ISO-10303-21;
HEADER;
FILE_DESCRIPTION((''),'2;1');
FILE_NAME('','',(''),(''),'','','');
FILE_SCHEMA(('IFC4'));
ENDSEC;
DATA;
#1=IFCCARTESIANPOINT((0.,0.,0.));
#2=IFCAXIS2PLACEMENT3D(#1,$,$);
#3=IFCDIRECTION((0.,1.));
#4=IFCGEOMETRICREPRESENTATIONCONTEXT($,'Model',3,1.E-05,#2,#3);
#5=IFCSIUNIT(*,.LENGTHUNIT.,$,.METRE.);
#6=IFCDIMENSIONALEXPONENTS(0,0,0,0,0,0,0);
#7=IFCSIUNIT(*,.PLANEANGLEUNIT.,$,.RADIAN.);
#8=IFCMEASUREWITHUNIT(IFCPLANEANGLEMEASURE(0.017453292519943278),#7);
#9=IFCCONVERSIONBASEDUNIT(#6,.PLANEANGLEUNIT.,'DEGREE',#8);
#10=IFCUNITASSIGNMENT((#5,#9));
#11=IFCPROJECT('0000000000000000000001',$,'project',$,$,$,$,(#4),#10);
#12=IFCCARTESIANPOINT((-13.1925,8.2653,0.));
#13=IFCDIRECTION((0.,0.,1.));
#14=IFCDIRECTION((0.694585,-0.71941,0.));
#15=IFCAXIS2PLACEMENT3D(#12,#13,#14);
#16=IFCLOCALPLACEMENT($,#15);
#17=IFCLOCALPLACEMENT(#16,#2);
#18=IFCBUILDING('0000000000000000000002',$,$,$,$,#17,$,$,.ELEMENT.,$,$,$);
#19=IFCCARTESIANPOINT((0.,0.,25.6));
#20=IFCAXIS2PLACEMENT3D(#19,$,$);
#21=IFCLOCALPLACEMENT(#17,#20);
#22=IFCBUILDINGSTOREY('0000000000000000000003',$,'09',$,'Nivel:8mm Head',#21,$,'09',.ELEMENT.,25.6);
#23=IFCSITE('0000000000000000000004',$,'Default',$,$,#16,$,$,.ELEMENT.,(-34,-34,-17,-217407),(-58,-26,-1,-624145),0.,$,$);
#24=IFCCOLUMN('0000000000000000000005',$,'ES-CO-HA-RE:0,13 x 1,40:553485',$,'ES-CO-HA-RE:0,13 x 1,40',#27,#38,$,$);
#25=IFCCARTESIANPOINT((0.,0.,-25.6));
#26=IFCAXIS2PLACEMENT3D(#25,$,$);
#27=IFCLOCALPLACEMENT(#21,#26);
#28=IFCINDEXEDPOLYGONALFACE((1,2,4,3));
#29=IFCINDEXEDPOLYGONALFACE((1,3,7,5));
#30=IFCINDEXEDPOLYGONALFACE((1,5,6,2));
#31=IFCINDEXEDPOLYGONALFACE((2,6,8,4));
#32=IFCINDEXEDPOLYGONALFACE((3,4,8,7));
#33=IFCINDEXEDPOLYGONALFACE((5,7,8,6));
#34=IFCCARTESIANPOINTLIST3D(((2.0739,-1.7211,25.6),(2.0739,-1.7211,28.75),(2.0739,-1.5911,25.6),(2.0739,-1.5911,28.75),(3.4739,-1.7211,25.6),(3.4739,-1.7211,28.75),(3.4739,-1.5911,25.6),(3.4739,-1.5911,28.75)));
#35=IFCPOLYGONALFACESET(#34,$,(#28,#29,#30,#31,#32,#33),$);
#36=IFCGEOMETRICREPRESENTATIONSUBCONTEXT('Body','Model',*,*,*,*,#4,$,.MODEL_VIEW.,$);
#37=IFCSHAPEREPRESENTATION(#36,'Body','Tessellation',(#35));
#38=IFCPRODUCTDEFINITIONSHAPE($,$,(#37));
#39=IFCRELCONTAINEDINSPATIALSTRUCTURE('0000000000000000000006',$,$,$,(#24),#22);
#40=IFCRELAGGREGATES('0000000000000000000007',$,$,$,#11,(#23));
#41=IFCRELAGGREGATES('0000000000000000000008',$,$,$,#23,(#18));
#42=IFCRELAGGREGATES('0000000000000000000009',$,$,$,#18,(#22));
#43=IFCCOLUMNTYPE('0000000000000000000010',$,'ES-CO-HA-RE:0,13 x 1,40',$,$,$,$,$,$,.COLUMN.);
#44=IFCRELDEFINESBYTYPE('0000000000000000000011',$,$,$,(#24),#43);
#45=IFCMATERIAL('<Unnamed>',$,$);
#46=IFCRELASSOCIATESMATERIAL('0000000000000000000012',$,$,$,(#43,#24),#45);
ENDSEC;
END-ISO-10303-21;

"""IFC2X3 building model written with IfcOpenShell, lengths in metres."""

from ifc_helpers import new_model, entity, si_unit, converted_unit, direction, frame, frame_2d, origin, place, context, subcontext, project, spatial, rectangle, extrude, source, transform, mapped, material, type_object, type_shapes, element, save


model = new_model("IFC2X3")

# Units and contexts
model_context = context("Model", 3, precision=1e-05, world=origin(), true_north=direction((0.0, 1.0)))
body_context = subcontext(model_context, "Body", "Model", "MODEL_VIEW")
ifc_project = project(units=[si_unit("LENGTHUNIT", "METRE"), converted_unit("PLANEANGLEUNIT", "DEGREE", entity("IfcPlaneAngleMeasure", 0.017453292519943278), si_unit("PLANEANGLEUNIT", "RADIAN"), dimensions=[0, 0, 0, 0, 0, 0, 0])], contexts=[model_context])

# Site, building, storey
site_placement = place(None, frame((-13.1925, 8.2653, 0.0), z_axis=(0.0, 0.0, 1.0), x_axis=(0.694585, -0.71941, 0.0)))
site = spatial("IfcSite", under=ifc_project, at=site_placement, Name="Default", CompositionType="ELEMENT", RefLatitude=(-34, -34, -17, -217407), RefLongitude=(-58, -26, -1, -624145), RefElevation=0.0)
building_placement = place(site_placement, origin())
building = spatial("IfcBuilding", under=site, at=building_placement, CompositionType="ELEMENT")
storey_placement = place(building_placement, frame((0.0, 0.0, 25.6)))
storey = spatial("IfcBuildingStorey", under=building, at=storey_placement, Name="09", ObjectType="Nivel:8mm Head", LongName="09", CompositionType="ELEMENT", Elevation=25.6)

# Column
ifc_material_1 = material(Name="<Unnamed>")
column_type_1 = type_object("IfcColumnType", Name="ES-CO-HA-RE:0,13 x 1,40", PredefinedType="COLUMN", material=ifc_material_1)
shared_shape_1 = source(origin(), body_context, "Body", "SweptSolid", [
    extrude(rectangle(XDim=1.4, YDim=0.13, at=frame_2d((0.0, 0.0), x_axis=(1.0, 0.0))), frame((2.7739, -1.6561, 25.6), z_axis=(0.0, 0.0, 1.0), x_axis=(-1.0, 0.0, 0.0)), (0.0, 0.0, 1.0), 3.15),
])
type_shapes(column_type_1, [shared_shape_1])
column_1_placement = place(storey_placement, frame((0.0, 0.0, -25.6)))
element("IfcColumn", 1, at=column_1_placement, inside=storey, type_object=column_type_1, material=ifc_material_1, Name="ES-CO-HA-RE:0,13 x 1,40:553485", ObjectType="ES-CO-HA-RE:0,13 x 1,40", context=body_context, shape_type="MappedRepresentation", body=[
    mapped(shared_shape_1, transform((0.0, 0.0, 0.0), scale=1.0)),
])

save(model, "model.ifc")
